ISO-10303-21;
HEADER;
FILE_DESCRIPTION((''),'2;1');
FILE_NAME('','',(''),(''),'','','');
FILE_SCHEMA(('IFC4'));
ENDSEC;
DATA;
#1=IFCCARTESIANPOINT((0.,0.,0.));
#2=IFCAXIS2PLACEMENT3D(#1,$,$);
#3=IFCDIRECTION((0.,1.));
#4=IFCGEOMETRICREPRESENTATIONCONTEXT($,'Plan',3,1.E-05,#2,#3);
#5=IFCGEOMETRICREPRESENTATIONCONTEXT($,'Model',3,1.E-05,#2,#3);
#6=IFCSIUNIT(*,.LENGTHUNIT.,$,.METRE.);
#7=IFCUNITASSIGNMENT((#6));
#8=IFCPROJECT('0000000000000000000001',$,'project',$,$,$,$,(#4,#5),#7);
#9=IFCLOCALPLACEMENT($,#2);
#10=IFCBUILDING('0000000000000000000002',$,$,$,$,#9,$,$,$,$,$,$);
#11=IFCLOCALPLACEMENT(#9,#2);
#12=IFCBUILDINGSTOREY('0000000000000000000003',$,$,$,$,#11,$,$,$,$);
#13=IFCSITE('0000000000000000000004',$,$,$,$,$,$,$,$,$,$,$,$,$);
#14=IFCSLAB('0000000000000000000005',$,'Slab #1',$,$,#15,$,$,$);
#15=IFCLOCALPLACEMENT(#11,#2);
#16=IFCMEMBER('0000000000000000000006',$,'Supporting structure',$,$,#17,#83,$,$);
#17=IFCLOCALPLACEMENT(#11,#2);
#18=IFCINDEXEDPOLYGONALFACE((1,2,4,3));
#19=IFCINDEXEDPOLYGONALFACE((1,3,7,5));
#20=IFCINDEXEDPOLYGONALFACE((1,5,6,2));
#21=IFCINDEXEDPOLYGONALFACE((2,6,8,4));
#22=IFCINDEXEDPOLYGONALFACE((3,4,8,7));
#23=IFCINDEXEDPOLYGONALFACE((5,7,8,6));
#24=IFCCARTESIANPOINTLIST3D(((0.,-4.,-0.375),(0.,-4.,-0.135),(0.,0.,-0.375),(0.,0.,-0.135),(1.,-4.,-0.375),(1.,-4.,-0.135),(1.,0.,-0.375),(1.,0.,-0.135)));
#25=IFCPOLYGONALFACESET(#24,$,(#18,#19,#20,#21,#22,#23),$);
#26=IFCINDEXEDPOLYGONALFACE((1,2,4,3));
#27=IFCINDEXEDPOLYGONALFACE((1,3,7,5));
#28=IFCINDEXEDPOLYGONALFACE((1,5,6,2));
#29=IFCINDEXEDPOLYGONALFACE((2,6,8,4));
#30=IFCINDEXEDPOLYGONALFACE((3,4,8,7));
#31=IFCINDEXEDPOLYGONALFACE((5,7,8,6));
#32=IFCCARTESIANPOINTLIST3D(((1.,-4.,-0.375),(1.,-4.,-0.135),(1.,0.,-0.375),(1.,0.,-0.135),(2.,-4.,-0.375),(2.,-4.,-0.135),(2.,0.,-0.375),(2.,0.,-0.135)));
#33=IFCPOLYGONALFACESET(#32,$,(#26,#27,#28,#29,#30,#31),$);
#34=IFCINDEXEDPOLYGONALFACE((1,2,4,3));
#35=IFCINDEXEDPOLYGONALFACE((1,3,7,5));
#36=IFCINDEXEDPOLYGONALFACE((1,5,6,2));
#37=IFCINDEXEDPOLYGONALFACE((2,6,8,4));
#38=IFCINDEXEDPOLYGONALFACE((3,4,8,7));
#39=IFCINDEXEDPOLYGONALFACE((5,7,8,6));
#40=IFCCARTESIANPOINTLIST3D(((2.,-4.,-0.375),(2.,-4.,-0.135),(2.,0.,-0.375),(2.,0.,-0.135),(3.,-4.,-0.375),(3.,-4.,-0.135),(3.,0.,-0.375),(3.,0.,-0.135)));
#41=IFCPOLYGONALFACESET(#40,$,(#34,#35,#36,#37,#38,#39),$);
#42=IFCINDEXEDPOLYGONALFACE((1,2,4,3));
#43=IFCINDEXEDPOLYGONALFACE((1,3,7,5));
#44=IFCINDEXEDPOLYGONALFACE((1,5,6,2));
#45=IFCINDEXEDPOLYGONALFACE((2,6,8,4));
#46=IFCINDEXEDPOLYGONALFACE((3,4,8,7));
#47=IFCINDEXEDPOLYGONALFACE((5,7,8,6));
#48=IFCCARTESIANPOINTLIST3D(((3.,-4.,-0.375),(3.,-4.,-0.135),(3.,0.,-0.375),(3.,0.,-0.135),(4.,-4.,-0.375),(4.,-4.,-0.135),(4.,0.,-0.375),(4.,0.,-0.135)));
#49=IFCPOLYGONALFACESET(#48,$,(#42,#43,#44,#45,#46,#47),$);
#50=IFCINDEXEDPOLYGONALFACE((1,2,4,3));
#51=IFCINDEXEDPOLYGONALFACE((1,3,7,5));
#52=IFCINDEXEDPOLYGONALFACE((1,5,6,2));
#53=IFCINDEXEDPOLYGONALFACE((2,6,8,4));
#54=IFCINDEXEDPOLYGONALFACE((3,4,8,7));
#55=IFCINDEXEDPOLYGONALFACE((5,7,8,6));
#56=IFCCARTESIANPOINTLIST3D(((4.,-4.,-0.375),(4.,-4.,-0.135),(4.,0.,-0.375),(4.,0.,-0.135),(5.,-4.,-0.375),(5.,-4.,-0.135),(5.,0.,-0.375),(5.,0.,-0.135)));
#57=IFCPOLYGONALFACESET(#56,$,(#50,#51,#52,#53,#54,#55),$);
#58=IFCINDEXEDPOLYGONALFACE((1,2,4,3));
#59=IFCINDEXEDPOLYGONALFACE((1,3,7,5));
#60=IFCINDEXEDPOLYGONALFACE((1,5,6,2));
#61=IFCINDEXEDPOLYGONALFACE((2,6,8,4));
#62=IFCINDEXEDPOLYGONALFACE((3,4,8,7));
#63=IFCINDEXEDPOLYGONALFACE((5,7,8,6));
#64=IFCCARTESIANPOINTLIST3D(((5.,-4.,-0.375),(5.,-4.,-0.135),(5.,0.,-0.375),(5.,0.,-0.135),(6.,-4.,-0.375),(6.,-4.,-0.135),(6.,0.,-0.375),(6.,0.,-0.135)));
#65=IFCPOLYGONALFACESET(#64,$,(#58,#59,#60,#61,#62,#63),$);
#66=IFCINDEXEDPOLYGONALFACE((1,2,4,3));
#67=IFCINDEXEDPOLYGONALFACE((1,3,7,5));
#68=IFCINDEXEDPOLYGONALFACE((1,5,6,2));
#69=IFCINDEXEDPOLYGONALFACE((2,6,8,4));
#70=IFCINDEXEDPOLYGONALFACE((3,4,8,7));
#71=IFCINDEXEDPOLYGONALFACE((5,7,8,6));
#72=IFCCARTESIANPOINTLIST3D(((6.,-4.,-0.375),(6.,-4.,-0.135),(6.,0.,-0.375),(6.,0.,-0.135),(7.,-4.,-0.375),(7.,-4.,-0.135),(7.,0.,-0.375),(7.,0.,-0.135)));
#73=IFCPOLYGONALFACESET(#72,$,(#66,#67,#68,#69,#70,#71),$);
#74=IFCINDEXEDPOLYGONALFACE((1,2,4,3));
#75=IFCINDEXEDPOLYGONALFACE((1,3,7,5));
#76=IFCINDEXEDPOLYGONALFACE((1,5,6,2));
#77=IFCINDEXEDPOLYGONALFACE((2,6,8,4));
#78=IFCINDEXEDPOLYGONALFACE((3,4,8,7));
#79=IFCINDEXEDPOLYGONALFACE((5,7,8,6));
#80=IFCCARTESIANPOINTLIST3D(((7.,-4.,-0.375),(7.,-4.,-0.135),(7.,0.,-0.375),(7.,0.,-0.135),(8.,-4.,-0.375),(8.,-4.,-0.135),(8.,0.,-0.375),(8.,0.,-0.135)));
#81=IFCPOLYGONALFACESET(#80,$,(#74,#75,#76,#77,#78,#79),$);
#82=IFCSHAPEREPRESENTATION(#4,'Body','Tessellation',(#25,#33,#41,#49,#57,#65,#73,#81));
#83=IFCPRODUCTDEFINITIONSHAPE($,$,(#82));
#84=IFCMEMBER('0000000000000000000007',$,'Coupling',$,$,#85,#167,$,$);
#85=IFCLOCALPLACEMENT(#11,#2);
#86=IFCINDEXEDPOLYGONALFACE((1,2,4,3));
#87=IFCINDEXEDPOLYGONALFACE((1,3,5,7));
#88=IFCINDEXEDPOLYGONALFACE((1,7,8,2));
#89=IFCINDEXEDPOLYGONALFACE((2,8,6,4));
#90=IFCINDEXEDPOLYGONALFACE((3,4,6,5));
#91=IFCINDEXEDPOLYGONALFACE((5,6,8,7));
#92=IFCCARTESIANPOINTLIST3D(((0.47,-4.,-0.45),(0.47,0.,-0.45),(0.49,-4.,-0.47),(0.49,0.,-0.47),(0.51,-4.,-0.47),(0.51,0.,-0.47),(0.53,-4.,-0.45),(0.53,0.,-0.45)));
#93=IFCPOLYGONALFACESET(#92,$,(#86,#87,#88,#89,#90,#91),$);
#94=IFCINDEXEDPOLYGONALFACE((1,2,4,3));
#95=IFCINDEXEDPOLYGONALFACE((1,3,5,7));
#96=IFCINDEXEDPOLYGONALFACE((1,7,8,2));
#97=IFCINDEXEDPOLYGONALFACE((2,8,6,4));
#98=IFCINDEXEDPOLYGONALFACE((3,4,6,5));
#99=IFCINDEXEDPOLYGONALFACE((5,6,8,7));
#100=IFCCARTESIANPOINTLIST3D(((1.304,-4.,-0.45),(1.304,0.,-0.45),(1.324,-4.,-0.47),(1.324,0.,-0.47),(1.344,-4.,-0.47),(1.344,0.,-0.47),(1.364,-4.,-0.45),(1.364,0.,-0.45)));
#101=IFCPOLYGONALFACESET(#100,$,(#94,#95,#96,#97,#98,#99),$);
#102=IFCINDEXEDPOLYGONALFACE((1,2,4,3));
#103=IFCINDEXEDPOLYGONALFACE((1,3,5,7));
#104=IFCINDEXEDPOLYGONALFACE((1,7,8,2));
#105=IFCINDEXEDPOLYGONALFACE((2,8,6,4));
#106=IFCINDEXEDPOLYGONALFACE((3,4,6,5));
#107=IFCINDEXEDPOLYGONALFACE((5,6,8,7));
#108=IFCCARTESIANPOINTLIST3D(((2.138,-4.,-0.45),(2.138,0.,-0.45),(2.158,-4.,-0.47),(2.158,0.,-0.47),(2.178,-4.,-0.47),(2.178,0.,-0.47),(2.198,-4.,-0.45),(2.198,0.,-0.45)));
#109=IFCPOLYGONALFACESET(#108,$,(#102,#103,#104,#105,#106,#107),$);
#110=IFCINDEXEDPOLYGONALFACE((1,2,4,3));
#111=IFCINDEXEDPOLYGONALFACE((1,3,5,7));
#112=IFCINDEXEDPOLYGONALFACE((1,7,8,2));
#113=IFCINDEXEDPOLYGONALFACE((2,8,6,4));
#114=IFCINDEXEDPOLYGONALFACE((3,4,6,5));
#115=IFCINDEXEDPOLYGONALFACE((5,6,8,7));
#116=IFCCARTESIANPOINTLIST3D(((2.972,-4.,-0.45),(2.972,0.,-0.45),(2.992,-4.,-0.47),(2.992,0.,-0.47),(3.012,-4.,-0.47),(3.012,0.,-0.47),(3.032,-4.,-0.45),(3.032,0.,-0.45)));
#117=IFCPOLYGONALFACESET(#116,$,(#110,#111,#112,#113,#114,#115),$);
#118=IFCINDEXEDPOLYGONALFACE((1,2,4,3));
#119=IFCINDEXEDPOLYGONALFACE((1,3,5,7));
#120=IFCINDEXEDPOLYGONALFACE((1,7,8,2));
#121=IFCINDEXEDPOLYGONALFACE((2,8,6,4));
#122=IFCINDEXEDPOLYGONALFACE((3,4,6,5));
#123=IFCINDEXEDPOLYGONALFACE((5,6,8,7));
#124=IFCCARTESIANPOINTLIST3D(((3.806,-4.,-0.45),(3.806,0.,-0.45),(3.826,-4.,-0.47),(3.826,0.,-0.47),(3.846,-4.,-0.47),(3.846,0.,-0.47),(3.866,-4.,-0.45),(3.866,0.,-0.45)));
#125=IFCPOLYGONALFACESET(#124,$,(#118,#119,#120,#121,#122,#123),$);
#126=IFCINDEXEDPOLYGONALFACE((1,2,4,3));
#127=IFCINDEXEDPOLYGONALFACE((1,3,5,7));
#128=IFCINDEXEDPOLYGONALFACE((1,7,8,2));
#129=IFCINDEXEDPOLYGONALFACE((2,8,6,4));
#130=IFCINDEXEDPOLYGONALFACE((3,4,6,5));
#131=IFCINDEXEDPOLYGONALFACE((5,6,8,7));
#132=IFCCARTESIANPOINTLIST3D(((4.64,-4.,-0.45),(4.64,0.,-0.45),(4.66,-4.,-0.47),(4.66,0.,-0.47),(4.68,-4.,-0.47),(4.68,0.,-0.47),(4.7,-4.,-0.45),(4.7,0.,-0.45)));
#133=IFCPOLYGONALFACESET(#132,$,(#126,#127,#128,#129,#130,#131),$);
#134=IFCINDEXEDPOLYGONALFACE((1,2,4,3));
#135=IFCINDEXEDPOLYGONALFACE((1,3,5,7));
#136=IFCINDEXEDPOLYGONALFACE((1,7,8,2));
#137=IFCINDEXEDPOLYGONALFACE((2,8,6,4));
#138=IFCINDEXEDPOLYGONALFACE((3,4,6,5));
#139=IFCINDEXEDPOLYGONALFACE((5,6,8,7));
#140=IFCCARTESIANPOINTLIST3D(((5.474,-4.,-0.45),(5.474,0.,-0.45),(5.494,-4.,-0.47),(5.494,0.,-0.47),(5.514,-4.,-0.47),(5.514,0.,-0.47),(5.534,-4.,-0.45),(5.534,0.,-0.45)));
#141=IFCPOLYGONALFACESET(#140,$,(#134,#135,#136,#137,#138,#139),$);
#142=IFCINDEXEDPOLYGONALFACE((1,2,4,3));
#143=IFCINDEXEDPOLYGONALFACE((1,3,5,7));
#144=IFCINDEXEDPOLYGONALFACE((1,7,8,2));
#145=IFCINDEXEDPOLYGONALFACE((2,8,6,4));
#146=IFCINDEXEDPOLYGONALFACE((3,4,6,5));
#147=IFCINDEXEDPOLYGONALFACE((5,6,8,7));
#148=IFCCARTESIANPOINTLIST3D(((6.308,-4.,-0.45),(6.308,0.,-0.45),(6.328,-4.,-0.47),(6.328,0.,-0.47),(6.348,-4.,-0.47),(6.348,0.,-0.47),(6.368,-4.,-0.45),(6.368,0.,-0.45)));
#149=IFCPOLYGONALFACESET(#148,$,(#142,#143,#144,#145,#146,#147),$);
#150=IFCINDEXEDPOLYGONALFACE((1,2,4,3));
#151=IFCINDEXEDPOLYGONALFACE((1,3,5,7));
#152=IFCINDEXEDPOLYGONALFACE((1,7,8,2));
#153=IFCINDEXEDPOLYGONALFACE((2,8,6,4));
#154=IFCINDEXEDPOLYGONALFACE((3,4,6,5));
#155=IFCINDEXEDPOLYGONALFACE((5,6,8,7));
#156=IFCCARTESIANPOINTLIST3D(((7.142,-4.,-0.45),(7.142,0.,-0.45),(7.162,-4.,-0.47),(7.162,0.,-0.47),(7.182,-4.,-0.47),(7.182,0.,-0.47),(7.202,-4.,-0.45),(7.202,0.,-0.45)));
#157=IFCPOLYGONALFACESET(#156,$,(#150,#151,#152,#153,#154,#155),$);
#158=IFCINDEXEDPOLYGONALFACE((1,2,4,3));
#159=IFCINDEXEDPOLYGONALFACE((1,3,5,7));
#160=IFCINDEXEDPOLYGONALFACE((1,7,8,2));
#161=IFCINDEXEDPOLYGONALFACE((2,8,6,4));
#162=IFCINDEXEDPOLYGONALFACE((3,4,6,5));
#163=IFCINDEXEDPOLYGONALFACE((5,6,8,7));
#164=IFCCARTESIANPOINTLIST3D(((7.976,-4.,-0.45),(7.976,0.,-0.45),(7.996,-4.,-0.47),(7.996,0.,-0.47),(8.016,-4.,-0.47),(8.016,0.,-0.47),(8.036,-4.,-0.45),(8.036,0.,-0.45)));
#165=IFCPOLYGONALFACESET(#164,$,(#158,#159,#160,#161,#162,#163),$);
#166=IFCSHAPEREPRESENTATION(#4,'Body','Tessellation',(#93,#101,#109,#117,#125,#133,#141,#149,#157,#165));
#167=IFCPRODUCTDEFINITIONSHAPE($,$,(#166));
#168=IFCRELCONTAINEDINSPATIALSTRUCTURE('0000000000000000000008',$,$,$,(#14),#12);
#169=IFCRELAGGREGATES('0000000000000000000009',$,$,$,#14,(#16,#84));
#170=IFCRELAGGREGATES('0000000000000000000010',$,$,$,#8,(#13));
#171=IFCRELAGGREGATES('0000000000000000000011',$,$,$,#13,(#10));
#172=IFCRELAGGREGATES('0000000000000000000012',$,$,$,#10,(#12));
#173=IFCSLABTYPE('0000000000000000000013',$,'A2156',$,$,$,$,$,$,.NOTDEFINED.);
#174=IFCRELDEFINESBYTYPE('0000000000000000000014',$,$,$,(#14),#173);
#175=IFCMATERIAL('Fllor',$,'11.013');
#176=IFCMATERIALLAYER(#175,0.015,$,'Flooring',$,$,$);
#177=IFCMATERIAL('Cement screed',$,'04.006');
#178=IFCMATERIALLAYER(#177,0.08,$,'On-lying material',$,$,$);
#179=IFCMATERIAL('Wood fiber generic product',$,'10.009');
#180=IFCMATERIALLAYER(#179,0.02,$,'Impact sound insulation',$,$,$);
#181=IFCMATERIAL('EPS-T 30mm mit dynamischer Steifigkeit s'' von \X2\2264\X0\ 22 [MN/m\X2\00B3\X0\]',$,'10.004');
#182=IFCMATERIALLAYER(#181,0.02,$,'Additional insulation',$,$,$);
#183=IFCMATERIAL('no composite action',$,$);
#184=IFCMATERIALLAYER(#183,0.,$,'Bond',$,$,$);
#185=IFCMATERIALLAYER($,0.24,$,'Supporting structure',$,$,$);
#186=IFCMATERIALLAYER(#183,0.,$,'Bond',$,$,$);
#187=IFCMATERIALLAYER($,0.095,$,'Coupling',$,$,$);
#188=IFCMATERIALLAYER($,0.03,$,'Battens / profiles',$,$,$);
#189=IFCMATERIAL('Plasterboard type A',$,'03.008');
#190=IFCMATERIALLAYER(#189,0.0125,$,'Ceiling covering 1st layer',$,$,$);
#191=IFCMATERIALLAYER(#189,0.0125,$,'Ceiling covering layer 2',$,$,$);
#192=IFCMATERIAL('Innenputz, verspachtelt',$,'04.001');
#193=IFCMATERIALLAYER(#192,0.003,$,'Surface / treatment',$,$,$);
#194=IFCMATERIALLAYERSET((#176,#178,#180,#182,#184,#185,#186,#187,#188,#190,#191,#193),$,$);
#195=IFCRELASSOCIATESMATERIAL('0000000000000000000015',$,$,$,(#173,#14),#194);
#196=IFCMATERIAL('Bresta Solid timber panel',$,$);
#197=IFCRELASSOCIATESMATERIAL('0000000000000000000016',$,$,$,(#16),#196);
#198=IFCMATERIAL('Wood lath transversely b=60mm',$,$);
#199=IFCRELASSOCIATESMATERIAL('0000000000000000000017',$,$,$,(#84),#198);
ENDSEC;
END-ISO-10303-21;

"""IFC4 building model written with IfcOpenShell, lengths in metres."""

from ifc_helpers import new_model, si_unit, direction, frame, frame_2d, origin, place, context, project, spatial, polyline, rectangle, outline, extrude, material, layer, layer_set, type_object, element, aggregate, save


model = new_model("IFC4")

# Units and contexts
plan_context = context("Plan", 3, precision=1e-05, world=origin(), true_north=direction((0.0, 1.0)))
model_context = context("Model", 3, precision=1e-05, world=origin(), true_north=direction((0.0, 1.0)))
ifc_project = project(units=[si_unit("LENGTHUNIT", "METRE")], contexts=[plan_context, model_context])

# Site, building, storey
site = spatial("IfcSite", under=ifc_project)
building_placement = place(None, origin())
building = spatial("IfcBuilding", under=site, at=building_placement)
storey_placement = place(building_placement, origin())
storey = spatial("IfcBuildingStorey", under=building, at=storey_placement)

# Slab, members
ifc_material_1 = material(Name="Fllor", Category="11.013")
ifc_layer_1 = layer(ifc_material_1, 0.015, Name="Flooring")
ifc_material_2 = material(Name="Cement screed", Category="04.006")
ifc_layer_2 = layer(ifc_material_2, 0.08, Name="On-lying material")
ifc_material_3 = material(Name="Wood fiber generic product", Category="10.009")
ifc_layer_3 = layer(ifc_material_3, 0.02, Name="Impact sound insulation")
ifc_material_4 = material(Name="EPS-T 30mm mit dynamischer Steifigkeit s' von ≤ 22 [MN/m³]", Category="10.004")
ifc_layer_4 = layer(ifc_material_4, 0.02, Name="Additional insulation")
ifc_material_5 = material(Name="no composite action")
ifc_layer_5 = layer(ifc_material_5, 0.0, Name="Bond")
ifc_layer_6 = layer(None, 0.24, Name="Supporting structure")
ifc_layer_7 = layer(ifc_material_5, 0.0, Name="Bond")
ifc_layer_8 = layer(None, 0.095, Name="Coupling")
ifc_layer_9 = layer(None, 0.03, Name="Battens / profiles")
ifc_material_6 = material(Name="Plasterboard type A", Category="03.008")
ifc_layer_10 = layer(ifc_material_6, 0.0125, Name="Ceiling covering 1st layer")
ifc_layer_11 = layer(ifc_material_6, 0.0125, Name="Ceiling covering layer 2")
ifc_material_7 = material(Name="Innenputz, verspachtelt", Category="04.001")
ifc_layer_12 = layer(ifc_material_7, 0.003, Name="Surface / treatment")
ifc_layer_set = layer_set([ifc_layer_1, ifc_layer_2, ifc_layer_3, ifc_layer_4, ifc_layer_5, ifc_layer_6, ifc_layer_7, ifc_layer_8, ifc_layer_9, ifc_layer_10, ifc_layer_11, ifc_layer_12])
slab_type = type_object("IfcSlabType", Name="A2156", PredefinedType="NOTDEFINED", material=ifc_layer_set)
slab_placement = place(None, frame((0.0, 0.0, 0.0), z_axis=(0.0, 0.0, -1.0), x_axis=(1.0, 0.0, 0.0)))
slab = element("IfcSlab", 1, at=slab_placement, inside=storey, type_object=slab_type, material=ifc_layer_set, Name="Slab #1")
ifc_material_8 = material(Name="Bresta Solid timber panel")
member_1_placement = place(slab_placement, origin())
member_1 = element("IfcMember", 2, at=member_1_placement, material=ifc_material_8, Name="Supporting structure", context=plan_context, shape_type="SweptSolid", body=[
    extrude(rectangle(XDim=1.0, YDim=0.24, at=frame_2d((0.5, 0.12), x_axis=(1.0, 0.0))), frame((0.0, 4.0, 0.135), z_axis=(0.0, -1.0, 0.0), x_axis=(1.0, 0.0, 0.0)), (0.0, 0.0, 1.0), 4.0),
    extrude(rectangle(XDim=1.0, YDim=0.24, at=frame_2d((0.5, 0.12), x_axis=(1.0, 0.0))), frame((1.0, 4.0, 0.135), z_axis=(0.0, -1.0, 0.0), x_axis=(1.0, 0.0, 0.0)), (0.0, 0.0, 1.0), 4.0),
    extrude(rectangle(XDim=1.0, YDim=0.24, at=frame_2d((0.5, 0.12), x_axis=(1.0, 0.0))), frame((2.0, 4.0, 0.135), z_axis=(0.0, -1.0, 0.0), x_axis=(1.0, 0.0, 0.0)), (0.0, 0.0, 1.0), 4.0),
    extrude(rectangle(XDim=1.0, YDim=0.24, at=frame_2d((0.5, 0.12), x_axis=(1.0, 0.0))), frame((3.0, 4.0, 0.135), z_axis=(0.0, -1.0, 0.0), x_axis=(1.0, 0.0, 0.0)), (0.0, 0.0, 1.0), 4.0),
    extrude(rectangle(XDim=1.0, YDim=0.24, at=frame_2d((0.5, 0.12), x_axis=(1.0, 0.0))), frame((4.0, 4.0, 0.135), z_axis=(0.0, -1.0, 0.0), x_axis=(1.0, 0.0, 0.0)), (0.0, 0.0, 1.0), 4.0),
    extrude(rectangle(XDim=1.0, YDim=0.24, at=frame_2d((0.5, 0.12), x_axis=(1.0, 0.0))), frame((5.0, 4.0, 0.135), z_axis=(0.0, -1.0, 0.0), x_axis=(1.0, 0.0, 0.0)), (0.0, 0.0, 1.0), 4.0),
    extrude(rectangle(XDim=1.0, YDim=0.24, at=frame_2d((0.5, 0.12), x_axis=(1.0, 0.0))), frame((6.0, 4.0, 0.135), z_axis=(0.0, -1.0, 0.0), x_axis=(1.0, 0.0, 0.0)), (0.0, 0.0, 1.0), 4.0),
    extrude(rectangle(XDim=1.0, YDim=0.24, at=frame_2d((0.5, 0.12), x_axis=(1.0, 0.0))), frame((7.0, 4.0, 0.135), z_axis=(0.0, -1.0, 0.0), x_axis=(1.0, 0.0, 0.0)), (0.0, 0.0, 1.0), 4.0),
])
ifc_material_9 = material(Name="Wood lath transversely b=60mm")
member_2_placement = place(slab_placement, origin())
member_2 = element("IfcMember", 3, at=member_2_placement, material=ifc_material_9, Name="Coupling", context=plan_context, shape_type="SweptSolid", body=[
    extrude(outline(polyline([(0.0, 0.0), (0.06, 0.0), (0.04, 0.02), (0.02, 0.02), (0.0, 0.0)])), frame((0.47, 4.0, 0.45), z_axis=(0.0, -1.0, 0.0), x_axis=(1.0, 0.0, 0.0)), (0.0, 0.0, 1.0), 4.0),
    extrude(outline(polyline([(0.0, 0.0), (0.06, 0.0), (0.04, 0.02), (0.02, 0.02), (0.0, 0.0)])), frame((1.304, 4.0, 0.45), z_axis=(0.0, -1.0, 0.0), x_axis=(1.0, 0.0, 0.0)), (0.0, 0.0, 1.0), 4.0),
    extrude(outline(polyline([(0.0, 0.0), (0.06, 0.0), (0.04, 0.02), (0.02, 0.02), (0.0, 0.0)])), frame((2.138, 4.0, 0.45), z_axis=(0.0, -1.0, 0.0), x_axis=(1.0, 0.0, 0.0)), (0.0, 0.0, 1.0), 4.0),
    extrude(outline(polyline([(0.0, 0.0), (0.06, 0.0), (0.04, 0.02), (0.02, 0.02), (0.0, 0.0)])), frame((2.972, 4.0, 0.45), z_axis=(0.0, -1.0, 0.0), x_axis=(1.0, 0.0, 0.0)), (0.0, 0.0, 1.0), 4.0),
    extrude(outline(polyline([(0.0, 0.0), (0.06, 0.0), (0.04, 0.02), (0.02, 0.02), (0.0, 0.0)])), frame((3.806, 4.0, 0.45), z_axis=(0.0, -1.0, 0.0), x_axis=(1.0, 0.0, 0.0)), (0.0, 0.0, 1.0), 4.0),
    extrude(outline(polyline([(0.0, 0.0), (0.06, 0.0), (0.04, 0.02), (0.02, 0.02), (0.0, 0.0)])), frame((4.64, 4.0, 0.45), z_axis=(0.0, -1.0, 0.0), x_axis=(1.0, 0.0, 0.0)), (0.0, 0.0, 1.0), 4.0),
    extrude(outline(polyline([(0.0, 0.0), (0.06, 0.0), (0.04, 0.02), (0.02, 0.02), (0.0, 0.0)])), frame((5.474, 4.0, 0.45), z_axis=(0.0, -1.0, 0.0), x_axis=(1.0, 0.0, 0.0)), (0.0, 0.0, 1.0), 4.0),
    extrude(outline(polyline([(0.0, 0.0), (0.06, 0.0), (0.04, 0.02), (0.02, 0.02), (0.0, 0.0)])), frame((6.308, 4.0, 0.45), z_axis=(0.0, -1.0, 0.0), x_axis=(1.0, 0.0, 0.0)), (0.0, 0.0, 1.0), 4.0),
    extrude(outline(polyline([(0.0, 0.0), (0.06, 0.0), (0.04, 0.02), (0.02, 0.02), (0.0, 0.0)])), frame((7.142, 4.0, 0.45), z_axis=(0.0, -1.0, 0.0), x_axis=(1.0, 0.0, 0.0)), (0.0, 0.0, 1.0), 4.0),
    extrude(outline(polyline([(0.0, 0.0), (0.06, 0.0), (0.04, 0.02), (0.02, 0.02), (0.0, 0.0)])), frame((7.976, 4.0, 0.45), z_axis=(0.0, -1.0, 0.0), x_axis=(1.0, 0.0, 0.0)), (0.0, 0.0, 1.0), 4.0),
])
aggregate(slab, [member_1, member_2])

save(model, "model.ifc")
